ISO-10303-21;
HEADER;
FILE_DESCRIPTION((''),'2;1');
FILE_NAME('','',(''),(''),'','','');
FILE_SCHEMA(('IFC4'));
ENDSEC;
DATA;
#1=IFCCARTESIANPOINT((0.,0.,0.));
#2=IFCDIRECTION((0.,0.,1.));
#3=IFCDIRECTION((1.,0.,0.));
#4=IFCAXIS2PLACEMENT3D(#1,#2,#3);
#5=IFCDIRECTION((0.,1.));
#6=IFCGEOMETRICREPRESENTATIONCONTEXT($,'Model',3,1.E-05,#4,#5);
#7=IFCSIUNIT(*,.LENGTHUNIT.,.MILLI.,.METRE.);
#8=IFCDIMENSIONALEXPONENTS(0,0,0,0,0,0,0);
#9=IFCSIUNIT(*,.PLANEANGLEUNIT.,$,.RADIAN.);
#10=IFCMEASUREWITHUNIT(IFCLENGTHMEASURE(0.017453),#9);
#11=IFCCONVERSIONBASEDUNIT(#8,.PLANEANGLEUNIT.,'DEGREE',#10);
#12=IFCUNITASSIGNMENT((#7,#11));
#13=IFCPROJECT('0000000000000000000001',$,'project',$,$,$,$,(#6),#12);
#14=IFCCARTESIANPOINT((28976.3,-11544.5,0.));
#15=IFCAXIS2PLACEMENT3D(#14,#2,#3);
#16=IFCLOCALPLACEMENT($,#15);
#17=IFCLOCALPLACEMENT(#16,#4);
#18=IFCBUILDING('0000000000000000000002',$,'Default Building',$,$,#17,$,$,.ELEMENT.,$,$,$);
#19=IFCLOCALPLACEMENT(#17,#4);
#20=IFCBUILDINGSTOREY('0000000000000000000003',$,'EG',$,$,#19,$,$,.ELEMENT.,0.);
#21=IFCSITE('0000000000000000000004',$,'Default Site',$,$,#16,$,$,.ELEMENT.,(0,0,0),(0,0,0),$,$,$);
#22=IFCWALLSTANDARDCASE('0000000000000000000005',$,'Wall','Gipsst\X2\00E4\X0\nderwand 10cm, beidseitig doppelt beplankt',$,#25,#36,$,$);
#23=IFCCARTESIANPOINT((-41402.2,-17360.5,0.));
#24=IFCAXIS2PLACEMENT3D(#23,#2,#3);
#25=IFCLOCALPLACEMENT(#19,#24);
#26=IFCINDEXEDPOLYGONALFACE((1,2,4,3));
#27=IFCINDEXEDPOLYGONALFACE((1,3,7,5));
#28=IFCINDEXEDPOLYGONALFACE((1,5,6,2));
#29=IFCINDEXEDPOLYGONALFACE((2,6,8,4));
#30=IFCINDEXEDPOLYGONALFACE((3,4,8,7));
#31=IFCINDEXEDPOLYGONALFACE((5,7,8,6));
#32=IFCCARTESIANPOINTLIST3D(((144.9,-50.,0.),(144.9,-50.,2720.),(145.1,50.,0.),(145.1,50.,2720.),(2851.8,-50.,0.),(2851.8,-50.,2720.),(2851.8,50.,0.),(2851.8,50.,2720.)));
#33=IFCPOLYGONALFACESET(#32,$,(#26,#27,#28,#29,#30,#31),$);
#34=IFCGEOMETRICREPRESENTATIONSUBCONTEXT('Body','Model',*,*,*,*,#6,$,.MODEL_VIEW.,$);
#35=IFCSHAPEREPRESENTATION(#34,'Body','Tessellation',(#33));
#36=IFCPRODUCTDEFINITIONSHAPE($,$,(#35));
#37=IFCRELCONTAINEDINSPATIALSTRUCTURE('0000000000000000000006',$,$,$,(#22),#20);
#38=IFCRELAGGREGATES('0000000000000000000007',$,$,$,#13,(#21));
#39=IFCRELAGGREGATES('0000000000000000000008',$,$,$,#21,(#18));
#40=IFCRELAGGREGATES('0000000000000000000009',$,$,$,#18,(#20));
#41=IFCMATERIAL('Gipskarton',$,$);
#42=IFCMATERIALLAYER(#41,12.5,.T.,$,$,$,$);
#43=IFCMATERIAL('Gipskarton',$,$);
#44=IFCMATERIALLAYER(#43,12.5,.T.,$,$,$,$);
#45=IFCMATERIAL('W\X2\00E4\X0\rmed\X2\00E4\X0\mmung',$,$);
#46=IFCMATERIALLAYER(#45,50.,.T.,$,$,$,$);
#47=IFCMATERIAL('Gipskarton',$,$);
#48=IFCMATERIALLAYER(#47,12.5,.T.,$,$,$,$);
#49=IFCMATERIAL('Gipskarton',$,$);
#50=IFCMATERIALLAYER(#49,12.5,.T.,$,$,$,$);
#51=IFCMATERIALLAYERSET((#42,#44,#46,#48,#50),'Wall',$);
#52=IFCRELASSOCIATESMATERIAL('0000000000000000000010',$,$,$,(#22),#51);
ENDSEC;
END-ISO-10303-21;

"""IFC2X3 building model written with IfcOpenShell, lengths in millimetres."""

from ifc_helpers import new_model, entity, si_unit, converted_unit, direction, frame, origin_with_axes, place, context, subcontext, project, spatial, polyline, outline, extrude, material, layer, layer_set, layer_usage, element, save


model = new_model("IFC2X3")

# Units and contexts
model_context = context("Model", 3, precision=1e-05, world=origin_with_axes(), true_north=direction((0.0, 1.0)))
body_context = subcontext(model_context, "Body", "Model", "MODEL_VIEW")
ifc_project = project(units=[si_unit("LENGTHUNIT", "METRE", prefix="MILLI"), converted_unit("PLANEANGLEUNIT", "DEGREE", entity("IfcLengthMeasure", 0.017453), si_unit("PLANEANGLEUNIT", "RADIAN"), dimensions=[0, 0, 0, 0, 0, 0, 0])], contexts=[model_context])

# Site, building, storey
site_placement = place(None, frame((28976.3, -11544.5, 0.0), z_axis=(0.0, 0.0, 1.0), x_axis=(1.0, 0.0, 0.0)))
site = spatial("IfcSite", under=ifc_project, at=site_placement, Name="Default Site", CompositionType="ELEMENT", RefLatitude=(0, 0, 0), RefLongitude=(0, 0, 0))
building_placement = place(site_placement, origin_with_axes())
building = spatial("IfcBuilding", under=site, at=building_placement, Name="Default Building", CompositionType="ELEMENT")
storey_placement = place(building_placement, origin_with_axes())
storey = spatial("IfcBuildingStorey", under=building, at=storey_placement, Name="EG", CompositionType="ELEMENT", Elevation=0.0)

# Wall
ifc_material_1 = material(Name="Gipskarton")
ifc_layer_1 = layer(ifc_material_1, 12.5, ventilated=True)
ifc_material_2 = material(Name="Gipskarton")
ifc_layer_2 = layer(ifc_material_2, 12.5, ventilated=True)
ifc_material_3 = material(Name="Wärmedämmung")
ifc_layer_3 = layer(ifc_material_3, 50.0, ventilated=True)
ifc_material_4 = material(Name="Gipskarton")
ifc_layer_4 = layer(ifc_material_4, 12.5, ventilated=True)
ifc_material_5 = material(Name="Gipskarton")
ifc_layer_5 = layer(ifc_material_5, 12.5, ventilated=True)
ifc_layer_set_1 = layer_set([ifc_layer_1, ifc_layer_2, ifc_layer_3, ifc_layer_4, ifc_layer_5], Name="Wall")
ifc_layer_usage_1 = layer_usage(ifc_layer_set_1, "AXIS2", "POSITIVE", -50.0)
wall_1_placement = place(storey_placement, frame((-41402.2, -17360.5, 0.0), z_axis=(0.0, 0.0, 1.0), x_axis=(1.0, 0.0, 0.0)))
element("IfcWallStandardCase", 1, at=wall_1_placement, inside=storey, material=ifc_layer_usage_1, Name="Wall", Description="Gipsständerwand 10cm, beidseitig doppelt beplankt", context=body_context, shape_type="SweptSolid", body=[
    extrude(outline(polyline([(2851.8, 50.0), (145.1, 50.0), (144.9, -50.0), (2851.8, -50.0), (2851.8, 50.0)])), origin_with_axes(), (0.0, 0.0, 1.0), 2720.0),
])

save(model, "model.ifc")
